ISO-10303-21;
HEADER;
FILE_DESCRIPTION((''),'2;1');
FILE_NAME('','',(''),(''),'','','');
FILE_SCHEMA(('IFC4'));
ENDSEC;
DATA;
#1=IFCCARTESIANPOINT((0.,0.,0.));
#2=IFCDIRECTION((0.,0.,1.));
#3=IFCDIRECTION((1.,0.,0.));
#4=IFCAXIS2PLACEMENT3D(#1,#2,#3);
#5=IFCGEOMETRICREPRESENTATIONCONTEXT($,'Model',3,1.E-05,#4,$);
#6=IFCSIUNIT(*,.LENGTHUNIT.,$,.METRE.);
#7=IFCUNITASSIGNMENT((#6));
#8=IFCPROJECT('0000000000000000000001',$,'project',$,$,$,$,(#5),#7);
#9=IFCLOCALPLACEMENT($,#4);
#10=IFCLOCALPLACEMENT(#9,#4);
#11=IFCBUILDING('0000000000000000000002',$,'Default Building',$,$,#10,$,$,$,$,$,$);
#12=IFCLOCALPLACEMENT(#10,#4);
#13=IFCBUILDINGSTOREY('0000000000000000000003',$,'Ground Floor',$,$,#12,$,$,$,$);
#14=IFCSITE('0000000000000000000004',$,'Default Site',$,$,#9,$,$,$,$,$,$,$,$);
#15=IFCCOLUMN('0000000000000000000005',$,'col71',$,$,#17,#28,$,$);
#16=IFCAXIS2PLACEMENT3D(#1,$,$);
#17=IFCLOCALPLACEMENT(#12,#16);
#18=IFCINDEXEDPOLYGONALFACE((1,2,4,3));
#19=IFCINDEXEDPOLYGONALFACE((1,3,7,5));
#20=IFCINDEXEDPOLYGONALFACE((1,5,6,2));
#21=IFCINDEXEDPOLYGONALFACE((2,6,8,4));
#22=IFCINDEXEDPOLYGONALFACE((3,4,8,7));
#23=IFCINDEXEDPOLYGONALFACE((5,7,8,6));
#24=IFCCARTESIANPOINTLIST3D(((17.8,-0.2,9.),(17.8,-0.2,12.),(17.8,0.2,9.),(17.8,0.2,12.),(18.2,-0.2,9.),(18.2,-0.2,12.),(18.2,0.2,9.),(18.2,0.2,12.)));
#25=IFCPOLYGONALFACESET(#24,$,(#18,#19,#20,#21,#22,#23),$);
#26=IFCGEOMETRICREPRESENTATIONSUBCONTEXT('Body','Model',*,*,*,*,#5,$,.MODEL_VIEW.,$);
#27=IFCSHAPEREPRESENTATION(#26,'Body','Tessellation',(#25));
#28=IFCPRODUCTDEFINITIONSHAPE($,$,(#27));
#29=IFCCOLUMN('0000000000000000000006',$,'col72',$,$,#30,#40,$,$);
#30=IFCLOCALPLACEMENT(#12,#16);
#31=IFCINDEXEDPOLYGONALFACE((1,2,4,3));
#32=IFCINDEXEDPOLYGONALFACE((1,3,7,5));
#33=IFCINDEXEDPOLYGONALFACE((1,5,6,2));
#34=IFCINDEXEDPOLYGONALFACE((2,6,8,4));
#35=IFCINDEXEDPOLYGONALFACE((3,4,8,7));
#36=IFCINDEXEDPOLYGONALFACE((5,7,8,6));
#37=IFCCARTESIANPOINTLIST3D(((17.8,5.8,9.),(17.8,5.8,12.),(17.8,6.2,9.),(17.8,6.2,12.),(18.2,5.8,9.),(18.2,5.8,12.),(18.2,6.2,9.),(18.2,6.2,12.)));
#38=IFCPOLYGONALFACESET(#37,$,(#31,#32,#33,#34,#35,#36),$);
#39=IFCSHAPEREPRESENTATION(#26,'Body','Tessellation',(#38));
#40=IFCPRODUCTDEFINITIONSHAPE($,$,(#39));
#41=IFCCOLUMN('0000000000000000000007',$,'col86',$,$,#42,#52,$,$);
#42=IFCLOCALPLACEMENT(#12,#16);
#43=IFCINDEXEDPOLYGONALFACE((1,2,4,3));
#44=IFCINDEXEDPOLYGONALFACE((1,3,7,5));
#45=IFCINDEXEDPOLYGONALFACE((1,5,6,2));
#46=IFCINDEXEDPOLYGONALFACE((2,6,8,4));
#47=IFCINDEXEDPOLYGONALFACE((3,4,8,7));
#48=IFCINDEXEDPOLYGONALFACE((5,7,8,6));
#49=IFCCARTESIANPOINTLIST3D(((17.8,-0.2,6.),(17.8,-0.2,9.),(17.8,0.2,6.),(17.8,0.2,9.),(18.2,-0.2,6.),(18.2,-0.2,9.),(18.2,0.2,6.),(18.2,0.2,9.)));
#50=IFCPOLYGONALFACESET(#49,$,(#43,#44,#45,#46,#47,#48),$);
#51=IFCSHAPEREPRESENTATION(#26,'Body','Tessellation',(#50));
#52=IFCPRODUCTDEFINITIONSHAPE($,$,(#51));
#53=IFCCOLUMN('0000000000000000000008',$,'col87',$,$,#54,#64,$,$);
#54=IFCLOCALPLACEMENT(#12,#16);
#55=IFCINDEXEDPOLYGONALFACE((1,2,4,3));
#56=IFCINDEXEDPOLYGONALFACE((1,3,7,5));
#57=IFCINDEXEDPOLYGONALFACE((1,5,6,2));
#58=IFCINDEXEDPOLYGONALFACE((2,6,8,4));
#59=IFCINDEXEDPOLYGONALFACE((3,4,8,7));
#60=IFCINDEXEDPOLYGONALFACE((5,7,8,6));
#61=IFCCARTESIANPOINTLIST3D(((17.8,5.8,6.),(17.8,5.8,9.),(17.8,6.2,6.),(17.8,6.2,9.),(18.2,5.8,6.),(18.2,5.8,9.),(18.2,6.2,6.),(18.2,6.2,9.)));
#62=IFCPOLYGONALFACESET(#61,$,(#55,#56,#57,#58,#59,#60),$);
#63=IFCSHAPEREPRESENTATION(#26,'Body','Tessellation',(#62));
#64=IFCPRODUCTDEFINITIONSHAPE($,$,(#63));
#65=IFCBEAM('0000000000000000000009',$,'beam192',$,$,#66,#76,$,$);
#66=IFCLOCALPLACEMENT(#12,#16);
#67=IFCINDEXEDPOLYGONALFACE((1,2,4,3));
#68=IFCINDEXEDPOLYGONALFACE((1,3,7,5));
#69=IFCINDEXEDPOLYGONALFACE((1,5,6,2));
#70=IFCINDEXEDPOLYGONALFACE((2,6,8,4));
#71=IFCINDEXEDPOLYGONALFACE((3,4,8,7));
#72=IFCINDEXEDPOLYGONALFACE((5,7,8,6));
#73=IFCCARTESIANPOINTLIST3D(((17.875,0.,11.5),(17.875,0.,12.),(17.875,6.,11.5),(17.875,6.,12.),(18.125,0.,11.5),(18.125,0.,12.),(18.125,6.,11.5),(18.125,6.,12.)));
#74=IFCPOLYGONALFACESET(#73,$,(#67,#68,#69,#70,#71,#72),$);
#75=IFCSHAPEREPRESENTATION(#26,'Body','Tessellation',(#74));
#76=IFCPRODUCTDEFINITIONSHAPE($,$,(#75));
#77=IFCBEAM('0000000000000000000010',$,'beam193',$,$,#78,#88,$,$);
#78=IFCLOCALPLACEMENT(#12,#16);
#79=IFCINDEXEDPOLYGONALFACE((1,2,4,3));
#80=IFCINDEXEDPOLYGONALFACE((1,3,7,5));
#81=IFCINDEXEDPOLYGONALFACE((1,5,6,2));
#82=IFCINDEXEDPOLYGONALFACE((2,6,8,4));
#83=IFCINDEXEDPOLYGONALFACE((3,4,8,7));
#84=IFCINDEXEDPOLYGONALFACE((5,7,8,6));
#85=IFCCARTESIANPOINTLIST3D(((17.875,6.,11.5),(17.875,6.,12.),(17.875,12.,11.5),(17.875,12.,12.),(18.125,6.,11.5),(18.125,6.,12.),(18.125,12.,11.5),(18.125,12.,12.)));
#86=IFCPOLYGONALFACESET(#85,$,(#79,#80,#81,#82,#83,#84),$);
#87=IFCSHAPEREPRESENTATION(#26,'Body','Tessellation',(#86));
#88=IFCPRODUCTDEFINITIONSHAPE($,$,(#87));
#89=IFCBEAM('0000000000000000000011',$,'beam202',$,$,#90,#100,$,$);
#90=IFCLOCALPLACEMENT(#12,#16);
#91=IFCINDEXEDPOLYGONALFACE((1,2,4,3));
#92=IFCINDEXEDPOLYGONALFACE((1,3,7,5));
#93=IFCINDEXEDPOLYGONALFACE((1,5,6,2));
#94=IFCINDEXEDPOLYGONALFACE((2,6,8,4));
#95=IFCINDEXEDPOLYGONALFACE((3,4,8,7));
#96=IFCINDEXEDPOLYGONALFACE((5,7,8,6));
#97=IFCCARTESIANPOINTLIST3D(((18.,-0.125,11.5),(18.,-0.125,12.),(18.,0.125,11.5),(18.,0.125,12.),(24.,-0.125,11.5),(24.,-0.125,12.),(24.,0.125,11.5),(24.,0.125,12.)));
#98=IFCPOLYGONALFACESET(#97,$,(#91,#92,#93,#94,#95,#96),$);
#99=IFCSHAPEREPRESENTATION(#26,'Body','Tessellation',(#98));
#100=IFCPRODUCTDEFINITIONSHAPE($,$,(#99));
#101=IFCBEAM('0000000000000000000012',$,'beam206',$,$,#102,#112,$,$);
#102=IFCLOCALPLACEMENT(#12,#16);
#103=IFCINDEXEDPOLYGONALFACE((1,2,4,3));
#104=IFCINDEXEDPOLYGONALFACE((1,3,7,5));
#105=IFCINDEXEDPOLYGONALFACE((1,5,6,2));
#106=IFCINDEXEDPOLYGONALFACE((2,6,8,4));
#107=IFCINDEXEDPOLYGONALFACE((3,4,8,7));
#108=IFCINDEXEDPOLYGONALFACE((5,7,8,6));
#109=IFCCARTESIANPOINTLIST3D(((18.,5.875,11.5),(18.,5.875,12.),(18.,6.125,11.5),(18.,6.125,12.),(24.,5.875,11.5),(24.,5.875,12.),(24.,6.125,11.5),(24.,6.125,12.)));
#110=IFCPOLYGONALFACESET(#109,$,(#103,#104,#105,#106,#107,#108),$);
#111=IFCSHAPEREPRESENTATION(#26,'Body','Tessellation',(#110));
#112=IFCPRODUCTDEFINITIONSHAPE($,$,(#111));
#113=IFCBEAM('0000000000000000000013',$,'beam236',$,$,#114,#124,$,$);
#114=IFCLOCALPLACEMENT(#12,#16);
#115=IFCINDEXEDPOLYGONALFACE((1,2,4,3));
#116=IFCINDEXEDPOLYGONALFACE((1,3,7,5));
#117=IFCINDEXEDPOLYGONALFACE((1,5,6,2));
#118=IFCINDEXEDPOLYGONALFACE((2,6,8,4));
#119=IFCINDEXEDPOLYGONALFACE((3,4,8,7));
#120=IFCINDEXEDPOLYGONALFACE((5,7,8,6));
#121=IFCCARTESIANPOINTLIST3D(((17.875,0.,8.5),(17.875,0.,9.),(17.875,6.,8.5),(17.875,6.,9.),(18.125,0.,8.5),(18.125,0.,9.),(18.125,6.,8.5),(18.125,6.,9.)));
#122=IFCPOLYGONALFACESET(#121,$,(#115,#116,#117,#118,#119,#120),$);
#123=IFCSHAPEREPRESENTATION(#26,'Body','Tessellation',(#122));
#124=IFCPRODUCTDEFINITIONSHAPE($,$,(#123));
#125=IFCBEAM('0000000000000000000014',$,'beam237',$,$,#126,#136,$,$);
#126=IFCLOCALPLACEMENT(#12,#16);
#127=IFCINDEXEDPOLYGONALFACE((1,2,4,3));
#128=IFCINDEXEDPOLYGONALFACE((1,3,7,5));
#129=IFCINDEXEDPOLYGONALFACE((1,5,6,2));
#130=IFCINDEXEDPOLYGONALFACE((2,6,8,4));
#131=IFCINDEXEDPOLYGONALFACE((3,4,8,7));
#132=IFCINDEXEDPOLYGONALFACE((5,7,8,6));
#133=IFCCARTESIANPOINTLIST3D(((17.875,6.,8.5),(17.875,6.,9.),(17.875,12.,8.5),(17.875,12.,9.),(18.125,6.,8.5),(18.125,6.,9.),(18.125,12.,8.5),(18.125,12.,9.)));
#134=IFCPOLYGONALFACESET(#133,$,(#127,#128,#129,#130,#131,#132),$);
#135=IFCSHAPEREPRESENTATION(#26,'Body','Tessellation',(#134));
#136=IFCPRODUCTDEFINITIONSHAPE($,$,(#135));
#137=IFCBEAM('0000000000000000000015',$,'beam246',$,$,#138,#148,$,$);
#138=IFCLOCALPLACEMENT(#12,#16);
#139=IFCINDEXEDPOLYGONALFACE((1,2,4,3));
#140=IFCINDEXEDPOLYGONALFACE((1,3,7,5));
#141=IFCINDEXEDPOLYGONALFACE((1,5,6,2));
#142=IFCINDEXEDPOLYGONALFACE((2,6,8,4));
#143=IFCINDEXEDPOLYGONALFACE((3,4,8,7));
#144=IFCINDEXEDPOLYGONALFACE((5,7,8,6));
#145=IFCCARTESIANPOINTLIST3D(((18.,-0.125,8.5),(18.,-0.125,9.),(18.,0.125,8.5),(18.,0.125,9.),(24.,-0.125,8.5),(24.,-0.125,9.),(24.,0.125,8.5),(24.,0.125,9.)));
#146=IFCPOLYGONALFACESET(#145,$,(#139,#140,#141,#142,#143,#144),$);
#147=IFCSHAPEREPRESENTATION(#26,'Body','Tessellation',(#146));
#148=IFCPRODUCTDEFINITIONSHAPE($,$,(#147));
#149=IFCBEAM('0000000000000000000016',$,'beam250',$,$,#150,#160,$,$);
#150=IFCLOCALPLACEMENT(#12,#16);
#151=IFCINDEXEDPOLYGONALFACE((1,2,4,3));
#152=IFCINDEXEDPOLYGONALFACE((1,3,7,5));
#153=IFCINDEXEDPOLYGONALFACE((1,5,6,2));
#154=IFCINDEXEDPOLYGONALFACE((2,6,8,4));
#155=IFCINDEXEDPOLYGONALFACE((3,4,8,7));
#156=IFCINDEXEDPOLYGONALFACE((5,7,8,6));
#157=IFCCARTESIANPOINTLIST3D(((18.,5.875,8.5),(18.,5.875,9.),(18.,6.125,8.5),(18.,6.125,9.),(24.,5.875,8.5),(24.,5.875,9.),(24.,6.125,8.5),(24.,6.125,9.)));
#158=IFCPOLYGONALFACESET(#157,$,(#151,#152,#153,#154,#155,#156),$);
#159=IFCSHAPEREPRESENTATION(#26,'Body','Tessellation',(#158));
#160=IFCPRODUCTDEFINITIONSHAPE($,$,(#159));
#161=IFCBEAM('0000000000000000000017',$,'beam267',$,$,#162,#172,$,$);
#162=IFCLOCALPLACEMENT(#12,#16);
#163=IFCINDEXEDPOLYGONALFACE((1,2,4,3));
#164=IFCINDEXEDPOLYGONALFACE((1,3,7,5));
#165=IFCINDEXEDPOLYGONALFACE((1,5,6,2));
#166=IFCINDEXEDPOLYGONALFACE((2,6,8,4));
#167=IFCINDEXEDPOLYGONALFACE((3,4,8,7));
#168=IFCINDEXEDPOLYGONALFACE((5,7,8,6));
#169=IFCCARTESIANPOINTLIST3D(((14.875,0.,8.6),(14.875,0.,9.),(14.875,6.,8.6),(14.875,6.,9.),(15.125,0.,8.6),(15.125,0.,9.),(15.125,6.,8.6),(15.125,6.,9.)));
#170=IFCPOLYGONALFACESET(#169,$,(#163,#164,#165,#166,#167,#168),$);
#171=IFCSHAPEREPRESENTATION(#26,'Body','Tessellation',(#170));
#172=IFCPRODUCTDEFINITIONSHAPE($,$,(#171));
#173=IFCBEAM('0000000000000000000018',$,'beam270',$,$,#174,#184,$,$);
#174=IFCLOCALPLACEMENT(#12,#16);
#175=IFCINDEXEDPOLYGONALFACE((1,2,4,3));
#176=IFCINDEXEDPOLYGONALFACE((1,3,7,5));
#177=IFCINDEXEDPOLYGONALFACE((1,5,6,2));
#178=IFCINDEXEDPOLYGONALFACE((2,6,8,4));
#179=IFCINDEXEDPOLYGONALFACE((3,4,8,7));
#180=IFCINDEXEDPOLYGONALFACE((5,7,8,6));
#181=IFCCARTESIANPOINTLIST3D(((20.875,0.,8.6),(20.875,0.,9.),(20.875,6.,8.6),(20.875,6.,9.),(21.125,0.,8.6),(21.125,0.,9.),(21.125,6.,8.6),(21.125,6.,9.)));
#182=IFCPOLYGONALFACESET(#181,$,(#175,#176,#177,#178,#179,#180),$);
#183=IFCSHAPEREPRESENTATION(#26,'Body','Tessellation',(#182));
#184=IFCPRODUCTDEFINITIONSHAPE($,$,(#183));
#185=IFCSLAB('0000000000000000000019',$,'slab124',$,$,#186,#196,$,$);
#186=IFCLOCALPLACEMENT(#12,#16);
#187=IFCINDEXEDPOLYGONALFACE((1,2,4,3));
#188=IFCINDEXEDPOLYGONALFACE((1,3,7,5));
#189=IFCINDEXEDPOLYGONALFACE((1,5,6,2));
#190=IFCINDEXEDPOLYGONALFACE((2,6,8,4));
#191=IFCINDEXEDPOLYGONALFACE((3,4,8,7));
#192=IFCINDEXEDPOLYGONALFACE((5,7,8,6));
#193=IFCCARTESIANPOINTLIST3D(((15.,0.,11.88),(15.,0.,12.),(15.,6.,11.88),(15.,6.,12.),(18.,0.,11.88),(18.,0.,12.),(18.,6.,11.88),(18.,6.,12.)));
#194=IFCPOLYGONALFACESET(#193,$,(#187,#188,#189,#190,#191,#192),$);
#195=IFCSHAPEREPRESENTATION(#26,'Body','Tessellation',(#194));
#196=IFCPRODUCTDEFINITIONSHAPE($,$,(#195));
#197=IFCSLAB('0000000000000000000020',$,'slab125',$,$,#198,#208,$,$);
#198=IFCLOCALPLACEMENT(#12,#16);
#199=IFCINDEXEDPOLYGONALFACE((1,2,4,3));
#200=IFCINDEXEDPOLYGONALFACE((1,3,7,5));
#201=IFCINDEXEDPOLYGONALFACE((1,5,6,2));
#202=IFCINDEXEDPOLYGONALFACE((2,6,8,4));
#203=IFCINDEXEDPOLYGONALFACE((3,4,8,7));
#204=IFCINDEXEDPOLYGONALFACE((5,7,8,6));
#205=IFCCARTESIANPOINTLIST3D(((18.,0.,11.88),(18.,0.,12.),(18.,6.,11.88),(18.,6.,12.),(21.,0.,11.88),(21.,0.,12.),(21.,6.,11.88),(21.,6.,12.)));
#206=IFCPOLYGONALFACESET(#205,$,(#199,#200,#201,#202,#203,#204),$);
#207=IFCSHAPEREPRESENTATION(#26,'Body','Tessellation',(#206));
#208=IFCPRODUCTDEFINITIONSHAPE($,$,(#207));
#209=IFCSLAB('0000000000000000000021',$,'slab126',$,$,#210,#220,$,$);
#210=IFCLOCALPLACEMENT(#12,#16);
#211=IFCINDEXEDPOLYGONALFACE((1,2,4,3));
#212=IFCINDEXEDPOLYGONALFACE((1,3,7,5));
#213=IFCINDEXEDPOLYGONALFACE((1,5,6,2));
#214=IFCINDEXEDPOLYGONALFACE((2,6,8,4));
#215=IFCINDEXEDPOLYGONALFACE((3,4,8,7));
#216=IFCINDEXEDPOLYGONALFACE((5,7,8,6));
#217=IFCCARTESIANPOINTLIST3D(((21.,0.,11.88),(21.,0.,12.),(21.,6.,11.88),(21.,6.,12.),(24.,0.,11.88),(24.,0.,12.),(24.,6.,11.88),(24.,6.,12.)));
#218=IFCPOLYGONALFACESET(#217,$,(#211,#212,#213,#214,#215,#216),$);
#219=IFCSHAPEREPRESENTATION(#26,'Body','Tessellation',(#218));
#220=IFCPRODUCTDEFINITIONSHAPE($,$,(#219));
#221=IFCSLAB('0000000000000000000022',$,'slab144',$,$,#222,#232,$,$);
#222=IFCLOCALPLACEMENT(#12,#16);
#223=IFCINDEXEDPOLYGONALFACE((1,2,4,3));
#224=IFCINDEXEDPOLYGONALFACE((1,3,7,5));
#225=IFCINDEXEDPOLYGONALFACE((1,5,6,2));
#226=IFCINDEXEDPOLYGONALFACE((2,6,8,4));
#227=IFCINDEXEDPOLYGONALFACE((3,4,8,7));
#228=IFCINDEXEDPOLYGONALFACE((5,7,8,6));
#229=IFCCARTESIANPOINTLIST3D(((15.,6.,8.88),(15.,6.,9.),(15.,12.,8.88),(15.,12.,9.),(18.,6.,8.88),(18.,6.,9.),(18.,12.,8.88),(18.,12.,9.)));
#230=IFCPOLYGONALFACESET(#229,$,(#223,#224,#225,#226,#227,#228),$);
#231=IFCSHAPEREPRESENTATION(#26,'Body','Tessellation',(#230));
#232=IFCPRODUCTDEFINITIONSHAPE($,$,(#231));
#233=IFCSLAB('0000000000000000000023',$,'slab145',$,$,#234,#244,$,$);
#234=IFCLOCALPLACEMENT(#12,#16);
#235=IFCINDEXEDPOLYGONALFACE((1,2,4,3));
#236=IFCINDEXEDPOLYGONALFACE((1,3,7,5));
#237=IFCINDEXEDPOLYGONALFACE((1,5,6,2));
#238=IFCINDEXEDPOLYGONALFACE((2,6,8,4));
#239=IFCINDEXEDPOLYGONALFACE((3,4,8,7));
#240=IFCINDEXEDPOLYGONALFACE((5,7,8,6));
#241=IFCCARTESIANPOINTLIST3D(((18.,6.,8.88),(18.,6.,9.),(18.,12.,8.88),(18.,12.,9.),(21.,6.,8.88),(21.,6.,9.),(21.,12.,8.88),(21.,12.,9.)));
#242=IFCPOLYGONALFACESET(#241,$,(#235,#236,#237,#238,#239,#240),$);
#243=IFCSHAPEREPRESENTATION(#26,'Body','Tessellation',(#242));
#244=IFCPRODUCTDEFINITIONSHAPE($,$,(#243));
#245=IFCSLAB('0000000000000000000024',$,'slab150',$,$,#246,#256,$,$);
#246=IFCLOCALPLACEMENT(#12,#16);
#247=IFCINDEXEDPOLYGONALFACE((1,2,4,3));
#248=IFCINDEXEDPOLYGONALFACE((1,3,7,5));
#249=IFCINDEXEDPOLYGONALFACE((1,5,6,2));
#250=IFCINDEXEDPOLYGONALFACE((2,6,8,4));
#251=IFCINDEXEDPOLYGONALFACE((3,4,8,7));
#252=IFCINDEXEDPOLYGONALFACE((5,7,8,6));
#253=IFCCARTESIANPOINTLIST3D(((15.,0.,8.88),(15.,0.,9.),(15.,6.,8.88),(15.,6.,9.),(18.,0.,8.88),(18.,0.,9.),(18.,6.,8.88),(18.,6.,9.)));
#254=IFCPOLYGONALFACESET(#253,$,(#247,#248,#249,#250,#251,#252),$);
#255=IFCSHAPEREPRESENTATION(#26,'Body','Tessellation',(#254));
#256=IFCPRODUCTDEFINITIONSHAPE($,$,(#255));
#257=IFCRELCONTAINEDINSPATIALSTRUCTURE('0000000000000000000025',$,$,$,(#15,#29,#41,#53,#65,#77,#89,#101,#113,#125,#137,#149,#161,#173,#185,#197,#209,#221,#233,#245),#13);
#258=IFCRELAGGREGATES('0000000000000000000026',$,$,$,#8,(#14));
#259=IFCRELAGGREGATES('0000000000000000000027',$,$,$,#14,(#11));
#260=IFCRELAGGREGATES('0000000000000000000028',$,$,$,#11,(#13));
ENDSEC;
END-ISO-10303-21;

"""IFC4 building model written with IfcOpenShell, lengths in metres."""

from ifc_helpers import new_model, si_unit, frame, origin_with_axes, place, context, subcontext, project, spatial, indexed_curve, outline, extrude, element, save


model = new_model("IFC4")

# Units and contexts
model_context = context("Model", 3, precision=1e-05, world=origin_with_axes())
body_context = subcontext(model_context, "Body", "Model", "MODEL_VIEW")
ifc_project = project(units=[si_unit("LENGTHUNIT", "METRE")], contexts=[model_context])

# Site, building, storey
site_placement = place(None, origin_with_axes())
site = spatial("IfcSite", under=ifc_project, at=site_placement, Name="Default Site")
building_placement = place(site_placement, origin_with_axes())
building = spatial("IfcBuilding", under=site, at=building_placement, Name="Default Building")
storey_placement = place(building_placement, origin_with_axes())
storey = spatial("IfcBuildingStorey", under=building, at=storey_placement, Name="Ground Floor")

# Columns
for number, where, z_axis, x_axis, name in (
    (1, (17.8, -0.2, 9.0), (0.0, 0.0, 1.0), (1.0, 0.0, 0.0), "col71"),
    (2, (17.8, 5.8, 9.0), (0.0, 0.0, 1.0), (1.0, 0.0, 0.0), "col72"),
    (3, (17.8, -0.2, 6.0), (0.0, 0.0, 1.0), (1.0, 0.0, 0.0), "col86"),
    (4, (17.8, 5.8, 6.0), (0.0, 0.0, 1.0), (1.0, 0.0, 0.0), "col87"),
):
    element("IfcColumn", number, at=place(storey_placement, frame(where, z_axis=z_axis, x_axis=x_axis)), inside=storey, Name=name, context=body_context, shape_type="SweptSolid", body=[
        extrude(outline(indexed_curve([(0.0, 0.0), (0.0, 0.4), (0.4, 0.4), (0.4, 0.0), (0.0, 0.0)], self_intersect=False)), origin_with_axes(), (0.0, 0.0, 1.0), 3.0),
    ])

# Beams
for number, where, z_axis, x_axis, name in (
    (5, (18.125, 0.0, 11.5), (0.0, 0.0, 1.0), (0.0, 1.0, 0.0), "beam192"),
    (6, (18.125, 6.0, 11.5), (0.0, 0.0, 1.0), (0.0, 1.0, 0.0), "beam193"),
    (7, (18.0, -0.125, 11.5), (0.0, 0.0, 1.0), (1.0, 0.0, 0.0), "beam202"),
    (8, (18.0, 5.875, 11.5), (0.0, 0.0, 1.0), (1.0, 0.0, 0.0), "beam206"),
    (9, (18.125, 0.0, 8.5), (0.0, 0.0, 1.0), (0.0, 1.0, 0.0), "beam236"),
    (10, (18.125, 6.0, 8.5), (0.0, 0.0, 1.0), (0.0, 1.0, 0.0), "beam237"),
    (11, (18.0, -0.125, 8.5), (0.0, 0.0, 1.0), (1.0, 0.0, 0.0), "beam246"),
    (12, (18.0, 5.875, 8.5), (0.0, 0.0, 1.0), (1.0, 0.0, 0.0), "beam250"),
):
    element("IfcBeam", number, at=place(storey_placement, frame(where, z_axis=z_axis, x_axis=x_axis)), inside=storey, Name=name, context=body_context, shape_type="SweptSolid", body=[
        extrude(outline(indexed_curve([(0.0, 0.0), (0.0, 0.25), (6.0, 0.25), (6.0, 0.0), (0.0, 0.0)], self_intersect=False)), origin_with_axes(), (0.0, 0.0, 1.0), 0.5),
    ])
for number, where, z_axis, x_axis, name in (
    (13, (14.875, 6.0, 8.6), (0.0, 0.0, 1.0), (0.0, -1.0, 0.0), "beam267"),
    (14, (20.875, 6.0, 8.6), (0.0, 0.0, 1.0), (0.0, -1.0, 0.0), "beam270"),
):
    element("IfcBeam", number, at=place(storey_placement, frame(where, z_axis=z_axis, x_axis=x_axis)), inside=storey, Name=name, context=body_context, shape_type="SweptSolid", body=[
        extrude(outline(indexed_curve([(0.0, 0.0), (0.0, 0.25), (6.0, 0.25), (6.0, 0.0), (0.0, 0.0)], self_intersect=False)), origin_with_axes(), (0.0, 0.0, 1.0), 0.4),
    ])

# Slabs
for number, where, z_axis, x_axis, name in (
    (15, (15.0, 0.0, 11.88), (0.0, 0.0, 1.0), (1.0, 0.0, 0.0), "slab124"),
    (16, (18.0, 0.0, 11.88), (0.0, 0.0, 1.0), (1.0, 0.0, 0.0), "slab125"),
    (17, (21.0, 0.0, 11.88), (0.0, 0.0, 1.0), (1.0, 0.0, 0.0), "slab126"),
    (18, (15.0, 6.0, 8.88), (0.0, 0.0, 1.0), (1.0, 0.0, 0.0), "slab144"),
    (19, (18.0, 6.0, 8.88), (0.0, 0.0, 1.0), (1.0, 0.0, 0.0), "slab145"),
    (20, (15.0, 0.0, 8.88), (0.0, 0.0, 1.0), (1.0, 0.0, 0.0), "slab150"),
):
    element("IfcSlab", number, at=place(storey_placement, frame(where, z_axis=z_axis, x_axis=x_axis)), inside=storey, Name=name, context=body_context, shape_type="SweptSolid", body=[
        extrude(outline(indexed_curve([(0.0, 0.0), (0.0, 6.0), (3.0, 6.0), (3.0, 0.0), (0.0, 0.0)], self_intersect=False)), origin_with_axes(), (0.0, 0.0, 1.0), 0.12),
    ])

save(model, "model.ifc")
